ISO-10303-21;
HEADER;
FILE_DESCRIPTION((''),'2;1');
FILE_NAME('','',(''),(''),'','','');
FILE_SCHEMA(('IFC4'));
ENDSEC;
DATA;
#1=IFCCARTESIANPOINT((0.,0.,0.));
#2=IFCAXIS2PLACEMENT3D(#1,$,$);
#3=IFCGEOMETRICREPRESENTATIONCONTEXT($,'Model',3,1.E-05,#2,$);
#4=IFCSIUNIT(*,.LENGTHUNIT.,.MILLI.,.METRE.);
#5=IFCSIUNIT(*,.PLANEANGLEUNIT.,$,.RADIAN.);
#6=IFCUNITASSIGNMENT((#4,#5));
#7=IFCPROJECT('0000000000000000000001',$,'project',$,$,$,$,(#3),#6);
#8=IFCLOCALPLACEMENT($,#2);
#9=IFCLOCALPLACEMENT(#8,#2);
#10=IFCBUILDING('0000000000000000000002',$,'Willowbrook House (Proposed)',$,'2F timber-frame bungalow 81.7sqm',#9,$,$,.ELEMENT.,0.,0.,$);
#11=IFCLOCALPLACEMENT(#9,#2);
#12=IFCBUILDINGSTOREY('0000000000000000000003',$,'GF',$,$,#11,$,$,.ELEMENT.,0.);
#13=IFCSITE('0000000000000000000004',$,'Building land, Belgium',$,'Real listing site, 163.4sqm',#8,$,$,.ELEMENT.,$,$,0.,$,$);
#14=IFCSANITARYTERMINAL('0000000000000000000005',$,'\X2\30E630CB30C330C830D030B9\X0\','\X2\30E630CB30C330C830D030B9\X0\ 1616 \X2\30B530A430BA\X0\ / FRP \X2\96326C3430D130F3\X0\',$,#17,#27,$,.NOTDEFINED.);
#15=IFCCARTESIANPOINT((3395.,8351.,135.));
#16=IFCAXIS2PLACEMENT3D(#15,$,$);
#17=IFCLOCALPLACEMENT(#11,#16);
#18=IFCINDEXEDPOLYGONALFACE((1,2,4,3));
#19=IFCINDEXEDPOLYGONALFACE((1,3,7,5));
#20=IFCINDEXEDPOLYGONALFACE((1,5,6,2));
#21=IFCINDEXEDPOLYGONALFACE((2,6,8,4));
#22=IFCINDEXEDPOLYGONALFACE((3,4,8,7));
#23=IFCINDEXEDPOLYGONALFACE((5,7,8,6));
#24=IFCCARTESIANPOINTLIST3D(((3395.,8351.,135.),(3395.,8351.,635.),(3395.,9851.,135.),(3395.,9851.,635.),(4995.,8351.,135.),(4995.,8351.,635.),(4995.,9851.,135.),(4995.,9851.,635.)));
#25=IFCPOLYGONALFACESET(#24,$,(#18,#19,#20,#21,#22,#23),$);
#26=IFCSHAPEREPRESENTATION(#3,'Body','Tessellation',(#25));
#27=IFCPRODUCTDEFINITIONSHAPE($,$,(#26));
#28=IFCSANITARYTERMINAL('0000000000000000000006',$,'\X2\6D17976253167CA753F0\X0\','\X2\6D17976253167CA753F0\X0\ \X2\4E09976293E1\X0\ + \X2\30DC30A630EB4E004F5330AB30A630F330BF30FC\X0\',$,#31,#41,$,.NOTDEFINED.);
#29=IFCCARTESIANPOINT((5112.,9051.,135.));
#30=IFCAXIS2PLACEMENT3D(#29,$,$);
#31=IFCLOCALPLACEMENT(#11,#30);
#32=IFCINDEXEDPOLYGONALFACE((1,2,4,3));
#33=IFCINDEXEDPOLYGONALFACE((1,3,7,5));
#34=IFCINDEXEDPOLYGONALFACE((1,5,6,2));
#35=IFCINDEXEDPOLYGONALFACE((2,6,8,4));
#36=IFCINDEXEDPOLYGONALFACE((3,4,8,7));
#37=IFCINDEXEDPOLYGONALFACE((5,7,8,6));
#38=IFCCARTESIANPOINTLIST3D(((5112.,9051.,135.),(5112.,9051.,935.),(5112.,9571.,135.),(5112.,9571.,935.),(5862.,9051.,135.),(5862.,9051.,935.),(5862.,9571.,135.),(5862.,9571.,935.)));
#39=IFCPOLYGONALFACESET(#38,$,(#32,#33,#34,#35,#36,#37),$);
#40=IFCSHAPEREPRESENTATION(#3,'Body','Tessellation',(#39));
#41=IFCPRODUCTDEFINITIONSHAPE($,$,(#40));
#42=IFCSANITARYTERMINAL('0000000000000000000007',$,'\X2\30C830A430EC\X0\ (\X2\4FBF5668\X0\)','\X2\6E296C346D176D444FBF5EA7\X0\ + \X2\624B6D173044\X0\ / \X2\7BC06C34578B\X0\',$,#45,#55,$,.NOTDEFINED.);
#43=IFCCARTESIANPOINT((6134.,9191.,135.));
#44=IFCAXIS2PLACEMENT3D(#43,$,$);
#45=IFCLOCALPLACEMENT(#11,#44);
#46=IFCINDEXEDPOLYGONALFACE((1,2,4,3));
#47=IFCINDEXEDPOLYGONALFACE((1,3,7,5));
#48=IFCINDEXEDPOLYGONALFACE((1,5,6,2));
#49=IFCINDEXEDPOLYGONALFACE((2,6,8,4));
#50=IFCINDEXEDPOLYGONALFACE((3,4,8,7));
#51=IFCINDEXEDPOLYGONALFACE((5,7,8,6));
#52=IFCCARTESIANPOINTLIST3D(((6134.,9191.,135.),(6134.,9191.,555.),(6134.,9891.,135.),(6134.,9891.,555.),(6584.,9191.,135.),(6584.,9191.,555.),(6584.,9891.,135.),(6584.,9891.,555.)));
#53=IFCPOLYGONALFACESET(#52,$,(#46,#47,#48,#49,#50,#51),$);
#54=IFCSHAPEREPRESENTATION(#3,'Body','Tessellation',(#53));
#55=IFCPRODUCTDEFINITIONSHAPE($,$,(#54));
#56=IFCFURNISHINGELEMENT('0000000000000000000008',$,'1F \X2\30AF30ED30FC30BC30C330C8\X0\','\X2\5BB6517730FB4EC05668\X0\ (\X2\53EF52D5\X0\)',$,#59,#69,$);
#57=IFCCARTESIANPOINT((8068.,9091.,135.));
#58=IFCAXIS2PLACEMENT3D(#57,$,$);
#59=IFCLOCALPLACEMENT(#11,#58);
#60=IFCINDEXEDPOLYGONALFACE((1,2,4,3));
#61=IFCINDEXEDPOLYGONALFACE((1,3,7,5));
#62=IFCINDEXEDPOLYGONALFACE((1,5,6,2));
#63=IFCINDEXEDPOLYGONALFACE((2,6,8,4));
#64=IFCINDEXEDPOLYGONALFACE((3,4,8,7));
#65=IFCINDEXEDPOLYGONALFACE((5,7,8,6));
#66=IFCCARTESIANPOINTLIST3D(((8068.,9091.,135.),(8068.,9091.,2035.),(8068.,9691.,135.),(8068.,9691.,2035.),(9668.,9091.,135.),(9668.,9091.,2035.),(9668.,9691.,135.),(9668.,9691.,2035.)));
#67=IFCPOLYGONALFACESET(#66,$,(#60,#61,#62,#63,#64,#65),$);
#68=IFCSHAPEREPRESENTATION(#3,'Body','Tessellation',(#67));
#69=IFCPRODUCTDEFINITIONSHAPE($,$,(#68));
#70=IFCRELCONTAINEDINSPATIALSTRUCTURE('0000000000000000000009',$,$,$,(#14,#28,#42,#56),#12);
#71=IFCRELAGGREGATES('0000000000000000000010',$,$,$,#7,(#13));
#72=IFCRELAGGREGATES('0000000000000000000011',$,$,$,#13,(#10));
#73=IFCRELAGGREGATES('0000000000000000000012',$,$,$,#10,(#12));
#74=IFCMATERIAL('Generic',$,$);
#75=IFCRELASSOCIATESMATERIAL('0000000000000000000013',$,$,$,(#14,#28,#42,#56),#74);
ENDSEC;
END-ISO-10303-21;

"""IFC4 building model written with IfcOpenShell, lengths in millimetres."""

from ifc_helpers import new_model, si_unit, frame, frame_2d, origin, place, context, project, spatial, rectangle, extrude, material, element, save


model = new_model("IFC4")

# Units and contexts
model_context = context("Model", 3, precision=1e-05, world=origin())
ifc_project = project(units=[si_unit("LENGTHUNIT", "METRE", prefix="MILLI"), si_unit("PLANEANGLEUNIT", "RADIAN")], contexts=[model_context])

# Site, building, storey
site_placement = place(None, origin())
site = spatial("IfcSite", under=ifc_project, at=site_placement, Name="Building land, Belgium", ObjectType="Real listing site, 163.4sqm", CompositionType="ELEMENT", RefElevation=0.0)
building_placement = place(site_placement, origin())
building = spatial("IfcBuilding", under=site, at=building_placement, Name="Willowbrook House (Proposed)", ObjectType="2F timber-frame bungalow 81.7sqm", CompositionType="ELEMENT", ElevationOfRefHeight=0.0, ElevationOfTerrain=0.0)
storey_placement = place(building_placement, origin())
storey = spatial("IfcBuildingStorey", under=building, at=storey_placement, Name="GF", CompositionType="ELEMENT", Elevation=0.0)

# Shared definitions
ifc_material_1 = material(Name="Generic")

# Sanitary terminals
sanitary_terminal_1_placement = place(storey_placement, frame((3395.0, 8351.0, 135.0)))
element("IfcSanitaryTerminal", 1, at=sanitary_terminal_1_placement, inside=storey, material=ifc_material_1, Name="ユニットバス", Description="ユニットバス 1616 サイズ / FRP 防水パン", PredefinedType="NOTDEFINED", context=model_context, shape_type="SweptSolid", body=[
    extrude(rectangle(XDim=1600.0, YDim=1500.0, at=frame_2d((800.0, 750.0))), frame((3395.0, 8351.0, 135.0)), (0.0, 0.0, 1.0), 500.0),
])
sanitary_terminal_2_placement = place(storey_placement, frame((5112.0, 9051.0, 135.0)))
element("IfcSanitaryTerminal", 2, at=sanitary_terminal_2_placement, inside=storey, material=ifc_material_1, Name="洗面化粧台", Description="洗面化粧台 三面鏡 + ボウル一体カウンター", PredefinedType="NOTDEFINED", context=model_context, shape_type="SweptSolid", body=[
    extrude(rectangle(XDim=750.0, YDim=520.0, at=frame_2d((375.0, 260.0))), frame((5112.0, 9051.0, 135.0)), (0.0, 0.0, 1.0), 800.0),
])
sanitary_terminal_3_placement = place(storey_placement, frame((6134.0, 9191.0, 135.0)))
element("IfcSanitaryTerminal", 3, at=sanitary_terminal_3_placement, inside=storey, material=ifc_material_1, Name="トイレ (便器)", Description="温水洗浄便座 + 手洗い / 節水型", PredefinedType="NOTDEFINED", context=model_context, shape_type="SweptSolid", body=[
    extrude(rectangle(XDim=450.0, YDim=700.0, at=frame_2d((225.0, 350.0))), frame((6134.0, 9191.0, 135.0)), (0.0, 0.0, 1.0), 420.0),
])

# Furnishing element
furnishing_placement = place(storey_placement, frame((8068.0, 9091.0, 135.0)))
element("IfcFurnishingElement", 4, at=furnishing_placement, inside=storey, material=ifc_material_1, Name="1F クローゼット", Description="家具・什器 (可動)", context=model_context, shape_type="SweptSolid", body=[
    extrude(rectangle(XDim=1600.0, YDim=600.0, at=frame_2d((800.0, 300.0))), frame((8068.0, 9091.0, 135.0)), (0.0, 0.0, 1.0), 1900.0),
])

save(model, "model.ifc")
